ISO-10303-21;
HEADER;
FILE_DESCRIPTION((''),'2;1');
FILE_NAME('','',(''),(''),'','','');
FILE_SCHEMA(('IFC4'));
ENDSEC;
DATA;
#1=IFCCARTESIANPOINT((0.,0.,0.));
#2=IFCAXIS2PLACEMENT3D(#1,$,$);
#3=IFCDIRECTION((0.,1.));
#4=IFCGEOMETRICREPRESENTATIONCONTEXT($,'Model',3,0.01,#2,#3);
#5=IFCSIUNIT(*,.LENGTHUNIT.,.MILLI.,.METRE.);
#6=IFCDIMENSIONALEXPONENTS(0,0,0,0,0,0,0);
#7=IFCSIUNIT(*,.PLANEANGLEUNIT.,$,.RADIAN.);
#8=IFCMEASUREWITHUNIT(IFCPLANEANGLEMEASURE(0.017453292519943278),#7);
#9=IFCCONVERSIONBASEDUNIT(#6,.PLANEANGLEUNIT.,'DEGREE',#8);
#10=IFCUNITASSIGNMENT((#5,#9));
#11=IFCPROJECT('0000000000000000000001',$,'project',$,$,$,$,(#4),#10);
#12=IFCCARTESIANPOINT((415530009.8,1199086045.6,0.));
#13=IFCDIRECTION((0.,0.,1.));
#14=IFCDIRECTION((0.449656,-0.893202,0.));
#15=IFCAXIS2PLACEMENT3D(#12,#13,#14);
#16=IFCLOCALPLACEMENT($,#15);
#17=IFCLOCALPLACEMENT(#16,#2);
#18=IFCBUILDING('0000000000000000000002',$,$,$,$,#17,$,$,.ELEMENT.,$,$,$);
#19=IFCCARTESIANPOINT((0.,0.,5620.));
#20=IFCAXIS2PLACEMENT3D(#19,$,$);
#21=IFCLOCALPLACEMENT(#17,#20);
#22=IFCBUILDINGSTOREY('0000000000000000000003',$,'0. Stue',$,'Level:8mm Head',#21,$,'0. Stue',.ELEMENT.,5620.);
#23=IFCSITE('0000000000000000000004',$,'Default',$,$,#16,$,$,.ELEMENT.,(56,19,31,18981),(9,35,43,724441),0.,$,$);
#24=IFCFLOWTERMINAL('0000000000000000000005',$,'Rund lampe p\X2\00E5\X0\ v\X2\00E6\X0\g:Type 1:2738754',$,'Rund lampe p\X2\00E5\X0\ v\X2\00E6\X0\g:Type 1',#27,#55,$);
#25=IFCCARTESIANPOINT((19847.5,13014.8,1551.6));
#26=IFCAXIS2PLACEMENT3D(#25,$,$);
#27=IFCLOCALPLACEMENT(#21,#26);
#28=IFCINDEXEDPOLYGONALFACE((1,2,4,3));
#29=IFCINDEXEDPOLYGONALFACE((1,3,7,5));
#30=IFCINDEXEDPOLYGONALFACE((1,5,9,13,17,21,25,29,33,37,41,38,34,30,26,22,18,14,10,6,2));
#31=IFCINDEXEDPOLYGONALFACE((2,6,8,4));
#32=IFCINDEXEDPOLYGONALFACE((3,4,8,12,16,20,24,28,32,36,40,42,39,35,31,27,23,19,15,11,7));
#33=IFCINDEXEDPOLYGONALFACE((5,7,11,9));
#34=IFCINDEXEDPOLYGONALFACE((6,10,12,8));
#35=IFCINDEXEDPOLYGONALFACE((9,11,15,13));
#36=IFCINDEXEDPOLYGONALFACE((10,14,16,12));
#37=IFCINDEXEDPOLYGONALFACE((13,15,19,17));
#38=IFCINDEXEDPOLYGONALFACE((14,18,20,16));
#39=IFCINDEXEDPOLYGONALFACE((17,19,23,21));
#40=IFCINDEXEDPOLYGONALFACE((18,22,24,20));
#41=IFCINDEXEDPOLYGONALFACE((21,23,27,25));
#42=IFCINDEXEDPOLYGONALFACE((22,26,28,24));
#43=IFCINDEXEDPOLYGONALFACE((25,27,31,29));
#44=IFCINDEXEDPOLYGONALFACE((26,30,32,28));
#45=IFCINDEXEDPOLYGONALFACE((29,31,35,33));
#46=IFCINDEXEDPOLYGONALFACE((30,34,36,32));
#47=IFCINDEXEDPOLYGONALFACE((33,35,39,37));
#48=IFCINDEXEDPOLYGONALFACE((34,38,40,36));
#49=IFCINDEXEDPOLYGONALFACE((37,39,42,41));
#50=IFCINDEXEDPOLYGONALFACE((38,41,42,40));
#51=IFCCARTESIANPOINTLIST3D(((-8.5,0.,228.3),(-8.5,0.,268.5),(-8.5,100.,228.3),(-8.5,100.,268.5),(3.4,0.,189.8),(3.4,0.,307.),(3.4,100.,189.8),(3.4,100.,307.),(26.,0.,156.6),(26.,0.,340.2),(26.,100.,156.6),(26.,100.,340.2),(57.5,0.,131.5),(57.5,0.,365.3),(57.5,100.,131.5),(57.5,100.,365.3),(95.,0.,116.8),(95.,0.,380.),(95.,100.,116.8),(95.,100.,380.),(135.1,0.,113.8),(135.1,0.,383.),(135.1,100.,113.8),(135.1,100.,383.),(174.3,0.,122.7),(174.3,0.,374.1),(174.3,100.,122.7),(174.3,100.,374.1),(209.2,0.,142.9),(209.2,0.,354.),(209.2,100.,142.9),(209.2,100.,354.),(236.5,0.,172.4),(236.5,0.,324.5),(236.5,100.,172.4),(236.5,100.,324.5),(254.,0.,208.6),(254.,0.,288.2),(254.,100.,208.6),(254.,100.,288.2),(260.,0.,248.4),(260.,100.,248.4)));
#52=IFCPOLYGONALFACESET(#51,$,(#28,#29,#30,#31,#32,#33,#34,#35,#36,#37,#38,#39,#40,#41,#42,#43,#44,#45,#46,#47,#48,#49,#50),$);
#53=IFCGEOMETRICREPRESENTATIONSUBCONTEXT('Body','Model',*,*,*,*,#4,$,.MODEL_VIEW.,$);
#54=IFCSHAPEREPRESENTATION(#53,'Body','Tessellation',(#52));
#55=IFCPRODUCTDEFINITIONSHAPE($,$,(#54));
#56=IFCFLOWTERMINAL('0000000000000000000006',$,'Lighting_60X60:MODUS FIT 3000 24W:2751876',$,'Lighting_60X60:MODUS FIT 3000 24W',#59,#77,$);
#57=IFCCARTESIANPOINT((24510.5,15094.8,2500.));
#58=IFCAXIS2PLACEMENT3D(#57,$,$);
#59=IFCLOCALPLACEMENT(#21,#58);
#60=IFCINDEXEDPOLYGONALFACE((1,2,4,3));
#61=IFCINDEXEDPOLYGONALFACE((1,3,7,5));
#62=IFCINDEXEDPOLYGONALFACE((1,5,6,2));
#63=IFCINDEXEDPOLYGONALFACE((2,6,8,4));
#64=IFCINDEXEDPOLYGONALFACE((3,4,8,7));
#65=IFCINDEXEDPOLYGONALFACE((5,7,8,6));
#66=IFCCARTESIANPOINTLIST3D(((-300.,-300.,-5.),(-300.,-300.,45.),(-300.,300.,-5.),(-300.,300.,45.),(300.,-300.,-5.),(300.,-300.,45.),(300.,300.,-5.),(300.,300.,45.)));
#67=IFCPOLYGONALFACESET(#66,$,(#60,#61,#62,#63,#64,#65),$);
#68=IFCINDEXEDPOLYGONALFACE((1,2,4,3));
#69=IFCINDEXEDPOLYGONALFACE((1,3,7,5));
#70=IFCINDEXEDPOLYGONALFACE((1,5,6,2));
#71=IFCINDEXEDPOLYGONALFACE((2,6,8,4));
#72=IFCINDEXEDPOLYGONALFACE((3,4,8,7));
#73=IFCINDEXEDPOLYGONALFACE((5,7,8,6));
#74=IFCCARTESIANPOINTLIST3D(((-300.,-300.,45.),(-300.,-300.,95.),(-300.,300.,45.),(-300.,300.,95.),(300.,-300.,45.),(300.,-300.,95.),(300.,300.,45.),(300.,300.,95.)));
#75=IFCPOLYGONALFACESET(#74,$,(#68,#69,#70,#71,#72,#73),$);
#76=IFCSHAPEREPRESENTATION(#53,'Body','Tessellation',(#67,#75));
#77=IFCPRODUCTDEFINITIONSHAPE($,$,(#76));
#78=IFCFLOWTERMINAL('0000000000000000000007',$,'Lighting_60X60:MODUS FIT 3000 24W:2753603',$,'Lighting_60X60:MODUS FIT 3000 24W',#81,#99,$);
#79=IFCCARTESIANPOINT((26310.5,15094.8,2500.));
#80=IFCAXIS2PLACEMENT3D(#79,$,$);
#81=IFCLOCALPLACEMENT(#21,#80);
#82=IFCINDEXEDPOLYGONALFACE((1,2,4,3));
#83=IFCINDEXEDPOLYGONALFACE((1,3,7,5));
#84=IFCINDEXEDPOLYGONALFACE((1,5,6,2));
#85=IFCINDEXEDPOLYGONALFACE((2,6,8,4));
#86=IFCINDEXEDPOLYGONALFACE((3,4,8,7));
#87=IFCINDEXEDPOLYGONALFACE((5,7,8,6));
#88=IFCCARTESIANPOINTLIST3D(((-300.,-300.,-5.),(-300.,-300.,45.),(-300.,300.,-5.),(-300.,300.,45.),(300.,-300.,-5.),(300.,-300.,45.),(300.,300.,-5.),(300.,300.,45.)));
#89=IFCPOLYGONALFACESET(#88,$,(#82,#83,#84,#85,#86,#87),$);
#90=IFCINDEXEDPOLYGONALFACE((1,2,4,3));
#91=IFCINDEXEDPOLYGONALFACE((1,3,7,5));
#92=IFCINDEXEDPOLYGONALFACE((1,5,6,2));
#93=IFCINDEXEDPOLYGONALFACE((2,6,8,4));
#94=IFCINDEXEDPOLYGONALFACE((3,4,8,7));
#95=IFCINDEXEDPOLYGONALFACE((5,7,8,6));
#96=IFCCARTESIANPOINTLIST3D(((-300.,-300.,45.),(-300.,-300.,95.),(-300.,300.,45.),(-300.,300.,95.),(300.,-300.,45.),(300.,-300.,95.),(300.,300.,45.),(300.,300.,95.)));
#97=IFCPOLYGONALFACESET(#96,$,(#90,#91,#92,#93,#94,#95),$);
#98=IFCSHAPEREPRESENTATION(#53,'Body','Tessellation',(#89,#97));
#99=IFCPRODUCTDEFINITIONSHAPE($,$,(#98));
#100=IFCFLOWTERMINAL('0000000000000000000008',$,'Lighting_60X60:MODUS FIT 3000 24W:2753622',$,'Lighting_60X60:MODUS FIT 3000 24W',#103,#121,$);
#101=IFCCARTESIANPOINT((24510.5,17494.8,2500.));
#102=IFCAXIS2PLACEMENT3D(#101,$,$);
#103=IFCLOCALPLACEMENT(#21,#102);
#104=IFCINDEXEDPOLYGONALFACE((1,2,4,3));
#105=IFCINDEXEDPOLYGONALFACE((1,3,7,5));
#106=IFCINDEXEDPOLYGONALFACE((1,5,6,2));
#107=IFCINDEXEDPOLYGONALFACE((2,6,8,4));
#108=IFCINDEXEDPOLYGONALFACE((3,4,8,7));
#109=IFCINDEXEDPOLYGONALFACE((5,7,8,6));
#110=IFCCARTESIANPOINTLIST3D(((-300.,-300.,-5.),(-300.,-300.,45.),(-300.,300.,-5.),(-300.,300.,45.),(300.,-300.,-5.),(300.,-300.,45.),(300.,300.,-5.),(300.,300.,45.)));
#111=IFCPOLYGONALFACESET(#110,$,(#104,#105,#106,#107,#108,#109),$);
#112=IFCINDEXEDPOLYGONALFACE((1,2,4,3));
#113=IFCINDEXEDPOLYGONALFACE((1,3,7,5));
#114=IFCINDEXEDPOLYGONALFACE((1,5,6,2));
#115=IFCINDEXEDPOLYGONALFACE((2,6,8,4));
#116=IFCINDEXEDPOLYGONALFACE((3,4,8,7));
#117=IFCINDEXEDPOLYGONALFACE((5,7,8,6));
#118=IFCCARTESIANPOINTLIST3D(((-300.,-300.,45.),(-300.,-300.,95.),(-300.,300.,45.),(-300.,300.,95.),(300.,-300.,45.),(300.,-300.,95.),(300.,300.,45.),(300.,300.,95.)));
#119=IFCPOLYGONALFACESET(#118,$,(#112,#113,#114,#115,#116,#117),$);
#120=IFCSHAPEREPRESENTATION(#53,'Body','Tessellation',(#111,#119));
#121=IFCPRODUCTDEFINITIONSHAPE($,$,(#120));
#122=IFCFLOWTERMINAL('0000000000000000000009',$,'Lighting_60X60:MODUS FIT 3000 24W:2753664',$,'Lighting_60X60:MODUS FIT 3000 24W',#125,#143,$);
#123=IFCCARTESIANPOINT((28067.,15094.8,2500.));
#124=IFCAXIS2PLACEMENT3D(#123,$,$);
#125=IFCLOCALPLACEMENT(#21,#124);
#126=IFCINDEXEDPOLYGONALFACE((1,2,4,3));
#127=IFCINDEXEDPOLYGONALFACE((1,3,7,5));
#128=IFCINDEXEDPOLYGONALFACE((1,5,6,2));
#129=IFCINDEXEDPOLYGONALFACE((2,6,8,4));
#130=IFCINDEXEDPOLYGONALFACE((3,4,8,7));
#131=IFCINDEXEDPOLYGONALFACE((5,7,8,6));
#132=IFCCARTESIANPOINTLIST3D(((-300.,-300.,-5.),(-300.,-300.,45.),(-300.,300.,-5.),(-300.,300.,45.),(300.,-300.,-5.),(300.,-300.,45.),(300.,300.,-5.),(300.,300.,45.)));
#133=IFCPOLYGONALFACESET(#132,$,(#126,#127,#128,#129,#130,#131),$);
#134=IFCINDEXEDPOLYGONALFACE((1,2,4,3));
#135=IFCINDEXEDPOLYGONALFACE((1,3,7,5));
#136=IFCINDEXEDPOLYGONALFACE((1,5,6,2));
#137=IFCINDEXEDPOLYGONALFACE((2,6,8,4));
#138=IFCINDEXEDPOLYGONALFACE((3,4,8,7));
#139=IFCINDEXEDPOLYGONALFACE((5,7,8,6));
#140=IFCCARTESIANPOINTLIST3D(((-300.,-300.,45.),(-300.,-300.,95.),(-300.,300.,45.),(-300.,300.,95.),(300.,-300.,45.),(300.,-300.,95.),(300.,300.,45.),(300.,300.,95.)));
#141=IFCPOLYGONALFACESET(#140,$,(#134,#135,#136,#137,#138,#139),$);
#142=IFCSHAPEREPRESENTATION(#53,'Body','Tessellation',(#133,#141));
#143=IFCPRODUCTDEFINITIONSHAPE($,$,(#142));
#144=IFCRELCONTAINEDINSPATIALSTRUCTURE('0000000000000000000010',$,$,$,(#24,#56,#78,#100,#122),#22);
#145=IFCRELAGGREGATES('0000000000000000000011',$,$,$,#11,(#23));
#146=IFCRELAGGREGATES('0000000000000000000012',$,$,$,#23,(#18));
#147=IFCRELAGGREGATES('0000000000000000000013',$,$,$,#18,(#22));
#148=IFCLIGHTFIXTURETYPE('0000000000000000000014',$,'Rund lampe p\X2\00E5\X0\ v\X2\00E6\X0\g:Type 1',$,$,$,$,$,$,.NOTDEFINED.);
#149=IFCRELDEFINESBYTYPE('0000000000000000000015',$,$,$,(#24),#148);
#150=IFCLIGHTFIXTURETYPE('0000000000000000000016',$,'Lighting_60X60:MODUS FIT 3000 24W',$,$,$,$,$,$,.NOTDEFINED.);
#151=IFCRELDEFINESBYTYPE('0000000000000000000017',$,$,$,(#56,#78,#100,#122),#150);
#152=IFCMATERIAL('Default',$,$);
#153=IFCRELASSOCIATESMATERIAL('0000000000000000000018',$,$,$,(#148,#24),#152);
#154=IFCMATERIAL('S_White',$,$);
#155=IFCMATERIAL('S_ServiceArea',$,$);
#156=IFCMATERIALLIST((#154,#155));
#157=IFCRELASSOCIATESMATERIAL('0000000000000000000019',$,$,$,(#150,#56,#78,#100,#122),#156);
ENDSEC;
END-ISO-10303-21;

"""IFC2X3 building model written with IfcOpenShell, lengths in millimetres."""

from ifc_helpers import new_model, entity, si_unit, converted_unit, direction, frame, frame_2d, origin, origin_2d_with_axis, place, context, subcontext, project, spatial, rectangle, circle, extrude, source, transform, mapped, material, material_list, type_object, type_shapes, element, save


model = new_model("IFC2X3")

# Units and contexts
model_context = context("Model", 3, precision=0.01, world=origin(), true_north=direction((0.0, 1.0)))
body_context = subcontext(model_context, "Body", "Model", "MODEL_VIEW")
ifc_project = project(units=[si_unit("LENGTHUNIT", "METRE", prefix="MILLI"), converted_unit("PLANEANGLEUNIT", "DEGREE", entity("IfcPlaneAngleMeasure", 0.017453292519943278), si_unit("PLANEANGLEUNIT", "RADIAN"), dimensions=[0, 0, 0, 0, 0, 0, 0])], contexts=[model_context])

# Site, building, storey
site_placement = place(None, frame((415530009.8, 1199086045.6, 0.0), z_axis=(0.0, 0.0, 1.0), x_axis=(0.449656, -0.893202, 0.0)))
site = spatial("IfcSite", under=ifc_project, at=site_placement, Name="Default", CompositionType="ELEMENT", RefLatitude=(56, 19, 31, 18981), RefLongitude=(9, 35, 43, 724441), RefElevation=0.0)
building_placement = place(site_placement, origin())
building = spatial("IfcBuilding", under=site, at=building_placement, CompositionType="ELEMENT")
storey_placement = place(building_placement, frame((0.0, 0.0, 5620.0)))
storey = spatial("IfcBuildingStorey", under=building, at=storey_placement, Name="0. Stue", ObjectType="Level:8mm Head", LongName="0. Stue", CompositionType="ELEMENT", Elevation=5620.0)

# Flow terminals
ifc_material_1 = material(Name="Default")
light_fixture_type_1 = type_object("IfcLightFixtureType", Name="Rund lampe på væg:Type 1", PredefinedType="NOTDEFINED", material=ifc_material_1)
shared_shape_1 = source(origin(), body_context, "Body", "SweptSolid", [
    extrude(circle(Radius=135.0, at=frame_2d((0.0, 0.0), x_axis=(1.0, 0.0))), frame((125.0, 0.0, 248.4), z_axis=(0.0, 1.0, 0.0), x_axis=(1.0, 0.0, 0.0)), (0.0, 0.0, 1.0), 100.0),
])
type_shapes(light_fixture_type_1, [shared_shape_1])
flow_terminal_placement = place(storey_placement, frame((19847.5, 13014.8, 1551.6)))
element("IfcFlowTerminal", 1, at=flow_terminal_placement, inside=storey, type_object=light_fixture_type_1, material=ifc_material_1, Name="Rund lampe på væg:Type 1:2738754", ObjectType="Rund lampe på væg:Type 1", context=body_context, shape_type="MappedRepresentation", body=[
    mapped(shared_shape_1, transform((0.0, 0.0, 0.0), scale=1.0)),
])
ifc_material_2 = material(Name="S_White")
ifc_material_3 = material(Name="S_ServiceArea")
ifc_material_list = material_list([ifc_material_2, ifc_material_3])
light_fixture_type_2 = type_object("IfcLightFixtureType", Name="Lighting_60X60:MODUS FIT 3000 24W", PredefinedType="NOTDEFINED", material=ifc_material_list)
shared_shape_2 = source(origin(), body_context, "Body", "SweptSolid", [
    extrude(rectangle(XDim=600.0, YDim=600.0, at=origin_2d_with_axis()), frame((0.0, 0.0, -5.0), z_axis=(0.0, 0.0, 1.0), x_axis=(-1.0, 0.0, 0.0)), (0.0, 0.0, 1.0), 50.0),
    extrude(rectangle(XDim=600.0, YDim=600.0, at=frame_2d((0.0, 0.0), x_axis=(1.0, 0.0))), frame((0.0, 0.0, 45.0), z_axis=(0.0, 0.0, 1.0), x_axis=(-1.0, 0.0, 0.0)), (0.0, 0.0, 1.0), 50.0),
])
type_shapes(light_fixture_type_2, [shared_shape_2])
for number, where, name in (
    (2, (24510.5, 15094.8, 2500.0), "Lighting_60X60:MODUS FIT 3000 24W:2751876"),
    (3, (26310.5, 15094.8, 2500.0), "Lighting_60X60:MODUS FIT 3000 24W:2753603"),
    (4, (24510.5, 17494.8, 2500.0), "Lighting_60X60:MODUS FIT 3000 24W:2753622"),
    (5, (28067.0, 15094.8, 2500.0), "Lighting_60X60:MODUS FIT 3000 24W:2753664"),
):
    element("IfcFlowTerminal", number, at=place(storey_placement, frame(where)), inside=storey, type_object=light_fixture_type_2, material=ifc_material_list, Name=name, ObjectType="Lighting_60X60:MODUS FIT 3000 24W", context=body_context, shape_type="MappedRepresentation", body=[
        mapped(shared_shape_2, transform((0.0, 0.0, 0.0), scale=1.0)),
    ])

save(model, "model.ifc")
